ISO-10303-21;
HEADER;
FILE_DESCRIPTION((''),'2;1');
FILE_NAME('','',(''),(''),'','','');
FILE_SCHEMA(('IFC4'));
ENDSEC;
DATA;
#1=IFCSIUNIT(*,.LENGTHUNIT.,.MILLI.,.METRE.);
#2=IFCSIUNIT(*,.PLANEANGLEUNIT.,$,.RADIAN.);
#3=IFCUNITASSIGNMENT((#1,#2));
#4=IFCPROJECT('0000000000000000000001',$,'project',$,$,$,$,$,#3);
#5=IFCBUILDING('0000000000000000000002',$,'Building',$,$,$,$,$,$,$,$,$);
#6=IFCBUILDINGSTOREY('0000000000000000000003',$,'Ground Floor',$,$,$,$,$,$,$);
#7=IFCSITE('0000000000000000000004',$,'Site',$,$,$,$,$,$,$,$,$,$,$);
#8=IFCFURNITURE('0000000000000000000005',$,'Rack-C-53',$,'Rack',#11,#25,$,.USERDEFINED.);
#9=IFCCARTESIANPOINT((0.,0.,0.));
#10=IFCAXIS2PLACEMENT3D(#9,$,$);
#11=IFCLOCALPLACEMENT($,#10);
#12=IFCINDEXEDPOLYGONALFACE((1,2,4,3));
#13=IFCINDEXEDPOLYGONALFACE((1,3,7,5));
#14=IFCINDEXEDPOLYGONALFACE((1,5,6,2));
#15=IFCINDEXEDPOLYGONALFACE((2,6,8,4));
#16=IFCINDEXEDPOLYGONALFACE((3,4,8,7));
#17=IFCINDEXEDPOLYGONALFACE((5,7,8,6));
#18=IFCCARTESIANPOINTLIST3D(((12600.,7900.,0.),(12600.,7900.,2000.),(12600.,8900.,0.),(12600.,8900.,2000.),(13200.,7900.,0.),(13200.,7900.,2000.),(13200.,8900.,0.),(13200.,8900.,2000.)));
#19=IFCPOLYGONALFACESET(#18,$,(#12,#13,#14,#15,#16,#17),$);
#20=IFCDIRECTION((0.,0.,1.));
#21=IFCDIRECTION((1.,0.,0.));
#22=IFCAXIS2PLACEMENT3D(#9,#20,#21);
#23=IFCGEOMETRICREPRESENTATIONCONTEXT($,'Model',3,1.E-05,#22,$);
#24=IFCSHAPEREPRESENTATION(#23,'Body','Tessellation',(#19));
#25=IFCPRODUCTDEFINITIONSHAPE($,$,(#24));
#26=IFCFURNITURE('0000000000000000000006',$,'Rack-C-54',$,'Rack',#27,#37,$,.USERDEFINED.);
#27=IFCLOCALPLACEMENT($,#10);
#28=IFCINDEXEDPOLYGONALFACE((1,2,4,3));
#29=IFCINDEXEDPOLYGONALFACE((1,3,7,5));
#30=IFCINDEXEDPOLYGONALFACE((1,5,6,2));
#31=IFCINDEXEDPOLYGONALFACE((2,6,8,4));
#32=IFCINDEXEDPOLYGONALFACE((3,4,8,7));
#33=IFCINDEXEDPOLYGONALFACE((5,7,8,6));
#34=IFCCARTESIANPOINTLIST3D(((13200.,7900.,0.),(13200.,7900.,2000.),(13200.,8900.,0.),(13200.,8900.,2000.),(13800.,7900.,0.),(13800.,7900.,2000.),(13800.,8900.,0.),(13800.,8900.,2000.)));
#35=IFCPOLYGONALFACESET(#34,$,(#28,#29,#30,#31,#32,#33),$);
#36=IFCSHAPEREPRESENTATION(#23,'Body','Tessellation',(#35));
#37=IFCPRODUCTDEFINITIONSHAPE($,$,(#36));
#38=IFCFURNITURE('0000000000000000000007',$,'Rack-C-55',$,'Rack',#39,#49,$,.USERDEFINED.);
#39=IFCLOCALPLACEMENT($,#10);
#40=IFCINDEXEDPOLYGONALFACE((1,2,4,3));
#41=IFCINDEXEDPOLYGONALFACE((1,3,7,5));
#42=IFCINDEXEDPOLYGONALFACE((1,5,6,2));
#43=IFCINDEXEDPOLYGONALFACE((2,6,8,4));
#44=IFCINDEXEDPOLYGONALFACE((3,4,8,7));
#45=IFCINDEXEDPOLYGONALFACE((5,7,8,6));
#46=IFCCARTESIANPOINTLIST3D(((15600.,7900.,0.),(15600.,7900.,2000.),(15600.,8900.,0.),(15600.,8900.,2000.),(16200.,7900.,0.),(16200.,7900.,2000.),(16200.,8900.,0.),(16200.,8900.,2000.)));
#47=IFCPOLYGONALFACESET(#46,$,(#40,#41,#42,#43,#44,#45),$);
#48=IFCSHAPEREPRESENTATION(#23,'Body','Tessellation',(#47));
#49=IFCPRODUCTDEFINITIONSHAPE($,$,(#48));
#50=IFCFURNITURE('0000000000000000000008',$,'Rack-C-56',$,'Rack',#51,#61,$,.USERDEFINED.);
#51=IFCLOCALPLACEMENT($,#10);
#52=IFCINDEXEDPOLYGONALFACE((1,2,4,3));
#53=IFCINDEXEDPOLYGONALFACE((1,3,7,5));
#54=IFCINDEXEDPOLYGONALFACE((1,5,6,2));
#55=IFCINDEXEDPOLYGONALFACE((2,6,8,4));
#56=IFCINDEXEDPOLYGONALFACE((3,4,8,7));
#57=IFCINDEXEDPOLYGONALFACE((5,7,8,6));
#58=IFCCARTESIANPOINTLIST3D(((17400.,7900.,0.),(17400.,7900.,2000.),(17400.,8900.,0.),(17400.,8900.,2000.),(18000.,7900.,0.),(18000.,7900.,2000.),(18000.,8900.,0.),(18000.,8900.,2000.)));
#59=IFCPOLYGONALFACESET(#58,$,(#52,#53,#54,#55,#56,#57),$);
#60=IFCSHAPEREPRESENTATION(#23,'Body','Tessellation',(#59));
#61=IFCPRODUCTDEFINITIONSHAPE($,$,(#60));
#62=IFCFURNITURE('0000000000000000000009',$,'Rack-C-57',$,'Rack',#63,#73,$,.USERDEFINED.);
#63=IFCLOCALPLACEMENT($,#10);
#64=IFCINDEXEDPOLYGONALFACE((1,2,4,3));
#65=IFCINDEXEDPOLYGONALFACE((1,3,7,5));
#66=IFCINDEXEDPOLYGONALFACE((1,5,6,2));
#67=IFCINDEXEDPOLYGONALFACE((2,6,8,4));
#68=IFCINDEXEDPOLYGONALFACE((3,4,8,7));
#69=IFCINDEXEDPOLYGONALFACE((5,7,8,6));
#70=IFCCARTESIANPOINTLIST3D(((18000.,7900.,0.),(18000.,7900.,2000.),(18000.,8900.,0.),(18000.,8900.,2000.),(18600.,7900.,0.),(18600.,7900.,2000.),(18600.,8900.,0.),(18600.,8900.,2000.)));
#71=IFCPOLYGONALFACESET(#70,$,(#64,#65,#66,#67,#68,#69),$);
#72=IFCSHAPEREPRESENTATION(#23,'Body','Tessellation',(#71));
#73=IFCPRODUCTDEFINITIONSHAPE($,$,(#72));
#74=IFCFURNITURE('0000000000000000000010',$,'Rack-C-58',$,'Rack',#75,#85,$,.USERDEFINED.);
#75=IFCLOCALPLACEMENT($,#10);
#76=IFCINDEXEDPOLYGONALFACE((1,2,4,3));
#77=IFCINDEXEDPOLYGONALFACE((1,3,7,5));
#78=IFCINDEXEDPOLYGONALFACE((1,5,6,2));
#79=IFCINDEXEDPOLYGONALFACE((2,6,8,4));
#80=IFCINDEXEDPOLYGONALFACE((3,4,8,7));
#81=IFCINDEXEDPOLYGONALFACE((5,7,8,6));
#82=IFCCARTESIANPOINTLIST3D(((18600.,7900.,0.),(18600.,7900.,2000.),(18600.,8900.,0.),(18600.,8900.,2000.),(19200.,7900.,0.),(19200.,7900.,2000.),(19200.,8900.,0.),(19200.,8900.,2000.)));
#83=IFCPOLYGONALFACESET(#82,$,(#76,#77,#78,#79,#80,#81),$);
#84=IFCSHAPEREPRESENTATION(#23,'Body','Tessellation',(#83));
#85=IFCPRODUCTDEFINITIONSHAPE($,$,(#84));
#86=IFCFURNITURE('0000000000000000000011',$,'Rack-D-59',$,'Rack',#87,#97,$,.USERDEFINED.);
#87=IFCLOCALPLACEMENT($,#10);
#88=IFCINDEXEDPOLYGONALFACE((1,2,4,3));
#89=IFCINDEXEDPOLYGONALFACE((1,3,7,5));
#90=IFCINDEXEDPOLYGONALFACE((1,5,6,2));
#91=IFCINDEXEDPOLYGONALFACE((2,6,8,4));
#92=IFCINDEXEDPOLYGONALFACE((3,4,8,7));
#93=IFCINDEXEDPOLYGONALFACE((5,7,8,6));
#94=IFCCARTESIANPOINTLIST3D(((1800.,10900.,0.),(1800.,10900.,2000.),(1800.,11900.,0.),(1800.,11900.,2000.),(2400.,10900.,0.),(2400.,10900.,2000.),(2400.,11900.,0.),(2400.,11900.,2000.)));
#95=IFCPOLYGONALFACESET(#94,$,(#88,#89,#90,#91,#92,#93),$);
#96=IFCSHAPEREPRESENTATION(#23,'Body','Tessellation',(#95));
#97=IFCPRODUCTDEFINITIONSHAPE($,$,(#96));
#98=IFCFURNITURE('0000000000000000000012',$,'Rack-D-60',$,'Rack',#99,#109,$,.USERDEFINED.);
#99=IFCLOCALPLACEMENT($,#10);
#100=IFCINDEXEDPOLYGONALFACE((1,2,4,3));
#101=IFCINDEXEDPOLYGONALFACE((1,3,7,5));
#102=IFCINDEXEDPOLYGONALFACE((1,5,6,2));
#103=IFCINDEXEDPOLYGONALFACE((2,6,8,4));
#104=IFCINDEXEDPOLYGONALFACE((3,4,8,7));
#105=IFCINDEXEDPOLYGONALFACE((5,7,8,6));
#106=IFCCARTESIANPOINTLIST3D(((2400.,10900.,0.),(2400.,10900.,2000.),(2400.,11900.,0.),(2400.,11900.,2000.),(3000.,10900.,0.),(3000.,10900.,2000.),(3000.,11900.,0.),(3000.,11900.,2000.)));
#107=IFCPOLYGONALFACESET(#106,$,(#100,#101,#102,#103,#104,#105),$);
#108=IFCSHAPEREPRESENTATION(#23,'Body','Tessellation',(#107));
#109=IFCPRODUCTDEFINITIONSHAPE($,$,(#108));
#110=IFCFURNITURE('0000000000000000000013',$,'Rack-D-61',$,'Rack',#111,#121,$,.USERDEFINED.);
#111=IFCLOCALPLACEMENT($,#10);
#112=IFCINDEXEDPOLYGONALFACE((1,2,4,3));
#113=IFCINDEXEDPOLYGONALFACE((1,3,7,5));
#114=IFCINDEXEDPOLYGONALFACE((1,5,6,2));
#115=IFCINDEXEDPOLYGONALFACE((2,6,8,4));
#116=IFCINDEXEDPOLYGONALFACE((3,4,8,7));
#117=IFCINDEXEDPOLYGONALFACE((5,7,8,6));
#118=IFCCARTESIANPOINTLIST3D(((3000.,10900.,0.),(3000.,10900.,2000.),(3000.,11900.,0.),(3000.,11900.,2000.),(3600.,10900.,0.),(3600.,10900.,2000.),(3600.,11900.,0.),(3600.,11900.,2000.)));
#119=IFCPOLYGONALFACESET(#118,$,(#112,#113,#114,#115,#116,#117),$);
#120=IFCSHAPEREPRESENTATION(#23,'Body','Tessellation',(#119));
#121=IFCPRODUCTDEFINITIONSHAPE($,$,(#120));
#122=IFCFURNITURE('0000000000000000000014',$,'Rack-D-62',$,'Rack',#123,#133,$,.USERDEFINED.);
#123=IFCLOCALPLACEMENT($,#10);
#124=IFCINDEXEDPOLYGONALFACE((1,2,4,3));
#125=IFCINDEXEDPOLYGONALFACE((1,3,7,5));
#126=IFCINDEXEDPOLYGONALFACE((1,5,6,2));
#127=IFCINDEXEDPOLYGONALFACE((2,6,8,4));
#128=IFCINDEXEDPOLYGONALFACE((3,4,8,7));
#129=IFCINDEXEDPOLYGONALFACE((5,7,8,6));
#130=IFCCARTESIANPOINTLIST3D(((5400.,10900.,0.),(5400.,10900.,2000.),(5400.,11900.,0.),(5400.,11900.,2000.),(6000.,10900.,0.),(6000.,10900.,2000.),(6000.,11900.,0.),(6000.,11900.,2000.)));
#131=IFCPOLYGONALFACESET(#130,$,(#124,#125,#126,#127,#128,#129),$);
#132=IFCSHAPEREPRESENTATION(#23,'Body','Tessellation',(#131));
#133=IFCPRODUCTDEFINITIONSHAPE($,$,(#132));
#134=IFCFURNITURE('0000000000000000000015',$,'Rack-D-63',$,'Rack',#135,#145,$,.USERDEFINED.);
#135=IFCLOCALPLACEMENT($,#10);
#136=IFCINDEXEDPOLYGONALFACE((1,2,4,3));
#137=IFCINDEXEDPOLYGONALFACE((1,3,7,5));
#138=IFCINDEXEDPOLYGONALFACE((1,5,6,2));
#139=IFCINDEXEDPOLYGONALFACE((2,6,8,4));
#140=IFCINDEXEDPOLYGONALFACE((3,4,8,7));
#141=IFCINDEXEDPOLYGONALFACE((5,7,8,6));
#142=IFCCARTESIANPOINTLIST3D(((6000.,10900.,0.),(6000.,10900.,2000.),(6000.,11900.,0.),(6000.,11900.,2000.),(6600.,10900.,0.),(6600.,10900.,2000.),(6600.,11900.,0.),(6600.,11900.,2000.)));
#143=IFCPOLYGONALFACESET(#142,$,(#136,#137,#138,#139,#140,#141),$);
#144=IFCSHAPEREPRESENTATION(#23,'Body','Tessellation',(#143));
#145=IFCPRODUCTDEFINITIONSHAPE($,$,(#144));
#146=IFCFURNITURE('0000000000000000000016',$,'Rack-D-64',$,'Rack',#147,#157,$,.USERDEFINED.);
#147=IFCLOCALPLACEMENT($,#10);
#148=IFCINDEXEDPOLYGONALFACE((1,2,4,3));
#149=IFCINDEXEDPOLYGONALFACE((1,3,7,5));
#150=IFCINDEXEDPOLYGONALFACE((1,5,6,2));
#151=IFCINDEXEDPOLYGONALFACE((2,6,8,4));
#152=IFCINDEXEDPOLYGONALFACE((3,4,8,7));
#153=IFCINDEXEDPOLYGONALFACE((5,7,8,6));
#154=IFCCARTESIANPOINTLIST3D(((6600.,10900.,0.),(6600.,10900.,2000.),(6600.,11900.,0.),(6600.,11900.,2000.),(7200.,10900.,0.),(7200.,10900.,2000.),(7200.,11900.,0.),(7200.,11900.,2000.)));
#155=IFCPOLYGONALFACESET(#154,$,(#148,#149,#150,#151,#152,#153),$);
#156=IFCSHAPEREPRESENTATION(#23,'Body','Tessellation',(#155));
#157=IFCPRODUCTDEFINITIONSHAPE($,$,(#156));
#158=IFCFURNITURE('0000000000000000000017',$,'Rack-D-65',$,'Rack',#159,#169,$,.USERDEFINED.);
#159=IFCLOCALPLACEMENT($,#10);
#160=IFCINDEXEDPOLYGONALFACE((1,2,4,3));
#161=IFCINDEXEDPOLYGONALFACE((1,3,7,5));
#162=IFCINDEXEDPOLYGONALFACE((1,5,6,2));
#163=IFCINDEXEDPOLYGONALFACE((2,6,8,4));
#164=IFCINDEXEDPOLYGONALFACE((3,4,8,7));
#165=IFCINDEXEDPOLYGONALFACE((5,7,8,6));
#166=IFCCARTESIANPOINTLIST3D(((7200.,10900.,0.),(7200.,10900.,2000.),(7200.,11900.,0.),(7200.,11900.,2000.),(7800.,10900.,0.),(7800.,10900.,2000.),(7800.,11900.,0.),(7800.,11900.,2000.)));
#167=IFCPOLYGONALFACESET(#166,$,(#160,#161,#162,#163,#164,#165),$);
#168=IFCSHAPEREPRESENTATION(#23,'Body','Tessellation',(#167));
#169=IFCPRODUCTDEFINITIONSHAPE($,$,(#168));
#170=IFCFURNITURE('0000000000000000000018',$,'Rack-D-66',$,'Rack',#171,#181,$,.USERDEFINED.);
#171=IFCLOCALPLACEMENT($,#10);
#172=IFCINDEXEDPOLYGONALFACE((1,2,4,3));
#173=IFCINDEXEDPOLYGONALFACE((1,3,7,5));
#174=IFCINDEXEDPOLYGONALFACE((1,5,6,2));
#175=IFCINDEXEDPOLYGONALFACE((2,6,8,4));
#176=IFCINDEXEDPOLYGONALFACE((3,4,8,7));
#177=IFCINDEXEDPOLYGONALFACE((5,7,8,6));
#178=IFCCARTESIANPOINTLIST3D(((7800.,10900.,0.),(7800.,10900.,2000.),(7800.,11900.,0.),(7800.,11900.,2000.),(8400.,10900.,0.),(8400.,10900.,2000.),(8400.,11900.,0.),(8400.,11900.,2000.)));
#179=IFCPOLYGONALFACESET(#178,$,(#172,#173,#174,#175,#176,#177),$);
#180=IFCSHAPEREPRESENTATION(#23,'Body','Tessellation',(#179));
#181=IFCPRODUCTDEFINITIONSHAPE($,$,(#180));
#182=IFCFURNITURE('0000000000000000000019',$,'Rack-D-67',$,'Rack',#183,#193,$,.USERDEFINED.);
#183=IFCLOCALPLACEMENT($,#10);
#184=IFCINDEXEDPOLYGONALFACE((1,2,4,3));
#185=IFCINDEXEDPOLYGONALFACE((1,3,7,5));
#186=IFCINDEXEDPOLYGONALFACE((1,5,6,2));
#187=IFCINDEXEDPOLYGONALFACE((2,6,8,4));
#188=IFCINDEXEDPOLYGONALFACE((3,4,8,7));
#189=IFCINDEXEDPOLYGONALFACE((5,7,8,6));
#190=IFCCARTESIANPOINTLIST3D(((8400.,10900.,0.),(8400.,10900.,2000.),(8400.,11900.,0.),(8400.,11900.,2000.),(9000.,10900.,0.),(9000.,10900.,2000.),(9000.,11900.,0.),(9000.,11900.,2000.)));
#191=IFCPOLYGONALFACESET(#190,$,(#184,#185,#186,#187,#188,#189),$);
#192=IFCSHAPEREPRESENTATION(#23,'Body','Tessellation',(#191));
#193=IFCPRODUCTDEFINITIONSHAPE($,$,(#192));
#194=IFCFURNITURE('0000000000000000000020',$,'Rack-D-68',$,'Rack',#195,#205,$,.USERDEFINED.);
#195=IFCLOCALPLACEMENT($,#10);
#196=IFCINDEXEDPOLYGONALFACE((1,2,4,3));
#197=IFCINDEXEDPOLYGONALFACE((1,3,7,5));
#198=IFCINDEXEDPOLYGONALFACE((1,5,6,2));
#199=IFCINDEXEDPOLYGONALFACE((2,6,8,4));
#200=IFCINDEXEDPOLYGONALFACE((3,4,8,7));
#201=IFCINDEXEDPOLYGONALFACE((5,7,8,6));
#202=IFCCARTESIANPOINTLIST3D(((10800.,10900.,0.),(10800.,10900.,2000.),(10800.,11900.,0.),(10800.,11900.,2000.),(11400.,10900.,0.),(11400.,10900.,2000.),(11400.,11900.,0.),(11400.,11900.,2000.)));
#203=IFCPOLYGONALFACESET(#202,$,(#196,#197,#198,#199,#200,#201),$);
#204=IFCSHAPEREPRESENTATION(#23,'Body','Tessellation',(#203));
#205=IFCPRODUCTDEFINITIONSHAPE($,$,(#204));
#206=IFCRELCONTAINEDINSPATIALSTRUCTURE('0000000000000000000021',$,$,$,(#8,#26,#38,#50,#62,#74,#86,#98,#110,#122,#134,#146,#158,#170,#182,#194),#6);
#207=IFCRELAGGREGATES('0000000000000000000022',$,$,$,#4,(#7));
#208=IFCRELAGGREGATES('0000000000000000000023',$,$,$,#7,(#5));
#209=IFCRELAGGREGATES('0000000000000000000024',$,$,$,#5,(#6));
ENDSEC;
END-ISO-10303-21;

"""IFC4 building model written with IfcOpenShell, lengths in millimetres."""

from ifc_helpers import new_model, si_unit, frame, origin_with_axes, place, context, project, spatial, rectangle, extrude, element, save


model = new_model("IFC4")

# Units and contexts
model_context = context("Model", 3, precision=1e-05, world=origin_with_axes())
ifc_project = project(units=[si_unit("LENGTHUNIT", "METRE", prefix="MILLI"), si_unit("PLANEANGLEUNIT", "RADIAN")])

# Site, building, storey
site = spatial("IfcSite", under=ifc_project, Name="Site")
building = spatial("IfcBuilding", under=site, Name="Building")
storey = spatial("IfcBuildingStorey", under=building, Name="Ground Floor")

# Furniture
furniture_1_placement = place(None, origin_with_axes())
element("IfcFurniture", 1, at=furniture_1_placement, inside=storey, Name="Rack-C-53", ObjectType="Rack", PredefinedType="USERDEFINED", context=model_context, shape_type="SweptSolid", body=[
    extrude(rectangle(XDim=600.0, YDim=1000.0), frame((12900.0, 8400.0, 0.0), z_axis=(0.0, 0.0, 1.0), x_axis=(1.0, 0.0, 0.0)), (0.0, 0.0, 1.0), 2000.0),
])
furniture_2_placement = place(None, origin_with_axes())
element("IfcFurniture", 2, at=furniture_2_placement, inside=storey, Name="Rack-C-54", ObjectType="Rack", PredefinedType="USERDEFINED", context=model_context, shape_type="SweptSolid", body=[
    extrude(rectangle(XDim=600.0, YDim=1000.0), frame((13500.0, 8400.0, 0.0), z_axis=(0.0, 0.0, 1.0), x_axis=(1.0, 0.0, 0.0)), (0.0, 0.0, 1.0), 2000.0),
])
furniture_3_placement = place(None, origin_with_axes())
element("IfcFurniture", 3, at=furniture_3_placement, inside=storey, Name="Rack-C-55", ObjectType="Rack", PredefinedType="USERDEFINED", context=model_context, shape_type="SweptSolid", body=[
    extrude(rectangle(XDim=600.0, YDim=1000.0), frame((15900.0, 8400.0, 0.0), z_axis=(0.0, 0.0, 1.0), x_axis=(1.0, 0.0, 0.0)), (0.0, 0.0, 1.0), 2000.0),
])
furniture_4_placement = place(None, origin_with_axes())
element("IfcFurniture", 4, at=furniture_4_placement, inside=storey, Name="Rack-C-56", ObjectType="Rack", PredefinedType="USERDEFINED", context=model_context, shape_type="SweptSolid", body=[
    extrude(rectangle(XDim=600.0, YDim=1000.0), frame((17700.0, 8400.0, 0.0), z_axis=(0.0, 0.0, 1.0), x_axis=(1.0, 0.0, 0.0)), (0.0, 0.0, 1.0), 2000.0),
])
furniture_5_placement = place(None, origin_with_axes())
element("IfcFurniture", 5, at=furniture_5_placement, inside=storey, Name="Rack-C-57", ObjectType="Rack", PredefinedType="USERDEFINED", context=model_context, shape_type="SweptSolid", body=[
    extrude(rectangle(XDim=600.0, YDim=1000.0), frame((18300.0, 8400.0, 0.0), z_axis=(0.0, 0.0, 1.0), x_axis=(1.0, 0.0, 0.0)), (0.0, 0.0, 1.0), 2000.0),
])
furniture_6_placement = place(None, origin_with_axes())
element("IfcFurniture", 6, at=furniture_6_placement, inside=storey, Name="Rack-C-58", ObjectType="Rack", PredefinedType="USERDEFINED", context=model_context, shape_type="SweptSolid", body=[
    extrude(rectangle(XDim=600.0, YDim=1000.0), frame((18900.0, 8400.0, 0.0), z_axis=(0.0, 0.0, 1.0), x_axis=(1.0, 0.0, 0.0)), (0.0, 0.0, 1.0), 2000.0),
])
furniture_7_placement = place(None, origin_with_axes())
element("IfcFurniture", 7, at=furniture_7_placement, inside=storey, Name="Rack-D-59", ObjectType="Rack", PredefinedType="USERDEFINED", context=model_context, shape_type="SweptSolid", body=[
    extrude(rectangle(XDim=600.0, YDim=1000.0), frame((2100.0, 11400.0, 0.0), z_axis=(0.0, 0.0, 1.0), x_axis=(1.0, 0.0, 0.0)), (0.0, 0.0, 1.0), 2000.0),
])
furniture_8_placement = place(None, origin_with_axes())
element("IfcFurniture", 8, at=furniture_8_placement, inside=storey, Name="Rack-D-60", ObjectType="Rack", PredefinedType="USERDEFINED", context=model_context, shape_type="SweptSolid", body=[
    extrude(rectangle(XDim=600.0, YDim=1000.0), frame((2700.0, 11400.0, 0.0), z_axis=(0.0, 0.0, 1.0), x_axis=(1.0, 0.0, 0.0)), (0.0, 0.0, 1.0), 2000.0),
])
furniture_9_placement = place(None, origin_with_axes())
element("IfcFurniture", 9, at=furniture_9_placement, inside=storey, Name="Rack-D-61", ObjectType="Rack", PredefinedType="USERDEFINED", context=model_context, shape_type="SweptSolid", body=[
    extrude(rectangle(XDim=600.0, YDim=1000.0), frame((3300.0, 11400.0, 0.0), z_axis=(0.0, 0.0, 1.0), x_axis=(1.0, 0.0, 0.0)), (0.0, 0.0, 1.0), 2000.0),
])
furniture_10_placement = place(None, origin_with_axes())
element("IfcFurniture", 10, at=furniture_10_placement, inside=storey, Name="Rack-D-62", ObjectType="Rack", PredefinedType="USERDEFINED", context=model_context, shape_type="SweptSolid", body=[
    extrude(rectangle(XDim=600.0, YDim=1000.0), frame((5700.0, 11400.0, 0.0), z_axis=(0.0, 0.0, 1.0), x_axis=(1.0, 0.0, 0.0)), (0.0, 0.0, 1.0), 2000.0),
])
furniture_11_placement = place(None, origin_with_axes())
element("IfcFurniture", 11, at=furniture_11_placement, inside=storey, Name="Rack-D-63", ObjectType="Rack", PredefinedType="USERDEFINED", context=model_context, shape_type="SweptSolid", body=[
    extrude(rectangle(XDim=600.0, YDim=1000.0), frame((6300.0, 11400.0, 0.0), z_axis=(0.0, 0.0, 1.0), x_axis=(1.0, 0.0, 0.0)), (0.0, 0.0, 1.0), 2000.0),
])
furniture_12_placement = place(None, origin_with_axes())
element("IfcFurniture", 12, at=furniture_12_placement, inside=storey, Name="Rack-D-64", ObjectType="Rack", PredefinedType="USERDEFINED", context=model_context, shape_type="SweptSolid", body=[
    extrude(rectangle(XDim=600.0, YDim=1000.0), frame((6900.0, 11400.0, 0.0), z_axis=(0.0, 0.0, 1.0), x_axis=(1.0, 0.0, 0.0)), (0.0, 0.0, 1.0), 2000.0),
])
furniture_13_placement = place(None, origin_with_axes())
element("IfcFurniture", 13, at=furniture_13_placement, inside=storey, Name="Rack-D-65", ObjectType="Rack", PredefinedType="USERDEFINED", context=model_context, shape_type="SweptSolid", body=[
    extrude(rectangle(XDim=600.0, YDim=1000.0), frame((7500.0, 11400.0, 0.0), z_axis=(0.0, 0.0, 1.0), x_axis=(1.0, 0.0, 0.0)), (0.0, 0.0, 1.0), 2000.0),
])
furniture_14_placement = place(None, origin_with_axes())
element("IfcFurniture", 14, at=furniture_14_placement, inside=storey, Name="Rack-D-66", ObjectType="Rack", PredefinedType="USERDEFINED", context=model_context, shape_type="SweptSolid", body=[
    extrude(rectangle(XDim=600.0, YDim=1000.0), frame((8100.0, 11400.0, 0.0), z_axis=(0.0, 0.0, 1.0), x_axis=(1.0, 0.0, 0.0)), (0.0, 0.0, 1.0), 2000.0),
])
furniture_15_placement = place(None, origin_with_axes())
element("IfcFurniture", 15, at=furniture_15_placement, inside=storey, Name="Rack-D-67", ObjectType="Rack", PredefinedType="USERDEFINED", context=model_context, shape_type="SweptSolid", body=[
    extrude(rectangle(XDim=600.0, YDim=1000.0), frame((8700.0, 11400.0, 0.0), z_axis=(0.0, 0.0, 1.0), x_axis=(1.0, 0.0, 0.0)), (0.0, 0.0, 1.0), 2000.0),
])
furniture_16_placement = place(None, origin_with_axes())
element("IfcFurniture", 16, at=furniture_16_placement, inside=storey, Name="Rack-D-68", ObjectType="Rack", PredefinedType="USERDEFINED", context=model_context, shape_type="SweptSolid", body=[
    extrude(rectangle(XDim=600.0, YDim=1000.0), frame((11100.0, 11400.0, 0.0), z_axis=(0.0, 0.0, 1.0), x_axis=(1.0, 0.0, 0.0)), (0.0, 0.0, 1.0), 2000.0),
])

save(model, "model.ifc")
